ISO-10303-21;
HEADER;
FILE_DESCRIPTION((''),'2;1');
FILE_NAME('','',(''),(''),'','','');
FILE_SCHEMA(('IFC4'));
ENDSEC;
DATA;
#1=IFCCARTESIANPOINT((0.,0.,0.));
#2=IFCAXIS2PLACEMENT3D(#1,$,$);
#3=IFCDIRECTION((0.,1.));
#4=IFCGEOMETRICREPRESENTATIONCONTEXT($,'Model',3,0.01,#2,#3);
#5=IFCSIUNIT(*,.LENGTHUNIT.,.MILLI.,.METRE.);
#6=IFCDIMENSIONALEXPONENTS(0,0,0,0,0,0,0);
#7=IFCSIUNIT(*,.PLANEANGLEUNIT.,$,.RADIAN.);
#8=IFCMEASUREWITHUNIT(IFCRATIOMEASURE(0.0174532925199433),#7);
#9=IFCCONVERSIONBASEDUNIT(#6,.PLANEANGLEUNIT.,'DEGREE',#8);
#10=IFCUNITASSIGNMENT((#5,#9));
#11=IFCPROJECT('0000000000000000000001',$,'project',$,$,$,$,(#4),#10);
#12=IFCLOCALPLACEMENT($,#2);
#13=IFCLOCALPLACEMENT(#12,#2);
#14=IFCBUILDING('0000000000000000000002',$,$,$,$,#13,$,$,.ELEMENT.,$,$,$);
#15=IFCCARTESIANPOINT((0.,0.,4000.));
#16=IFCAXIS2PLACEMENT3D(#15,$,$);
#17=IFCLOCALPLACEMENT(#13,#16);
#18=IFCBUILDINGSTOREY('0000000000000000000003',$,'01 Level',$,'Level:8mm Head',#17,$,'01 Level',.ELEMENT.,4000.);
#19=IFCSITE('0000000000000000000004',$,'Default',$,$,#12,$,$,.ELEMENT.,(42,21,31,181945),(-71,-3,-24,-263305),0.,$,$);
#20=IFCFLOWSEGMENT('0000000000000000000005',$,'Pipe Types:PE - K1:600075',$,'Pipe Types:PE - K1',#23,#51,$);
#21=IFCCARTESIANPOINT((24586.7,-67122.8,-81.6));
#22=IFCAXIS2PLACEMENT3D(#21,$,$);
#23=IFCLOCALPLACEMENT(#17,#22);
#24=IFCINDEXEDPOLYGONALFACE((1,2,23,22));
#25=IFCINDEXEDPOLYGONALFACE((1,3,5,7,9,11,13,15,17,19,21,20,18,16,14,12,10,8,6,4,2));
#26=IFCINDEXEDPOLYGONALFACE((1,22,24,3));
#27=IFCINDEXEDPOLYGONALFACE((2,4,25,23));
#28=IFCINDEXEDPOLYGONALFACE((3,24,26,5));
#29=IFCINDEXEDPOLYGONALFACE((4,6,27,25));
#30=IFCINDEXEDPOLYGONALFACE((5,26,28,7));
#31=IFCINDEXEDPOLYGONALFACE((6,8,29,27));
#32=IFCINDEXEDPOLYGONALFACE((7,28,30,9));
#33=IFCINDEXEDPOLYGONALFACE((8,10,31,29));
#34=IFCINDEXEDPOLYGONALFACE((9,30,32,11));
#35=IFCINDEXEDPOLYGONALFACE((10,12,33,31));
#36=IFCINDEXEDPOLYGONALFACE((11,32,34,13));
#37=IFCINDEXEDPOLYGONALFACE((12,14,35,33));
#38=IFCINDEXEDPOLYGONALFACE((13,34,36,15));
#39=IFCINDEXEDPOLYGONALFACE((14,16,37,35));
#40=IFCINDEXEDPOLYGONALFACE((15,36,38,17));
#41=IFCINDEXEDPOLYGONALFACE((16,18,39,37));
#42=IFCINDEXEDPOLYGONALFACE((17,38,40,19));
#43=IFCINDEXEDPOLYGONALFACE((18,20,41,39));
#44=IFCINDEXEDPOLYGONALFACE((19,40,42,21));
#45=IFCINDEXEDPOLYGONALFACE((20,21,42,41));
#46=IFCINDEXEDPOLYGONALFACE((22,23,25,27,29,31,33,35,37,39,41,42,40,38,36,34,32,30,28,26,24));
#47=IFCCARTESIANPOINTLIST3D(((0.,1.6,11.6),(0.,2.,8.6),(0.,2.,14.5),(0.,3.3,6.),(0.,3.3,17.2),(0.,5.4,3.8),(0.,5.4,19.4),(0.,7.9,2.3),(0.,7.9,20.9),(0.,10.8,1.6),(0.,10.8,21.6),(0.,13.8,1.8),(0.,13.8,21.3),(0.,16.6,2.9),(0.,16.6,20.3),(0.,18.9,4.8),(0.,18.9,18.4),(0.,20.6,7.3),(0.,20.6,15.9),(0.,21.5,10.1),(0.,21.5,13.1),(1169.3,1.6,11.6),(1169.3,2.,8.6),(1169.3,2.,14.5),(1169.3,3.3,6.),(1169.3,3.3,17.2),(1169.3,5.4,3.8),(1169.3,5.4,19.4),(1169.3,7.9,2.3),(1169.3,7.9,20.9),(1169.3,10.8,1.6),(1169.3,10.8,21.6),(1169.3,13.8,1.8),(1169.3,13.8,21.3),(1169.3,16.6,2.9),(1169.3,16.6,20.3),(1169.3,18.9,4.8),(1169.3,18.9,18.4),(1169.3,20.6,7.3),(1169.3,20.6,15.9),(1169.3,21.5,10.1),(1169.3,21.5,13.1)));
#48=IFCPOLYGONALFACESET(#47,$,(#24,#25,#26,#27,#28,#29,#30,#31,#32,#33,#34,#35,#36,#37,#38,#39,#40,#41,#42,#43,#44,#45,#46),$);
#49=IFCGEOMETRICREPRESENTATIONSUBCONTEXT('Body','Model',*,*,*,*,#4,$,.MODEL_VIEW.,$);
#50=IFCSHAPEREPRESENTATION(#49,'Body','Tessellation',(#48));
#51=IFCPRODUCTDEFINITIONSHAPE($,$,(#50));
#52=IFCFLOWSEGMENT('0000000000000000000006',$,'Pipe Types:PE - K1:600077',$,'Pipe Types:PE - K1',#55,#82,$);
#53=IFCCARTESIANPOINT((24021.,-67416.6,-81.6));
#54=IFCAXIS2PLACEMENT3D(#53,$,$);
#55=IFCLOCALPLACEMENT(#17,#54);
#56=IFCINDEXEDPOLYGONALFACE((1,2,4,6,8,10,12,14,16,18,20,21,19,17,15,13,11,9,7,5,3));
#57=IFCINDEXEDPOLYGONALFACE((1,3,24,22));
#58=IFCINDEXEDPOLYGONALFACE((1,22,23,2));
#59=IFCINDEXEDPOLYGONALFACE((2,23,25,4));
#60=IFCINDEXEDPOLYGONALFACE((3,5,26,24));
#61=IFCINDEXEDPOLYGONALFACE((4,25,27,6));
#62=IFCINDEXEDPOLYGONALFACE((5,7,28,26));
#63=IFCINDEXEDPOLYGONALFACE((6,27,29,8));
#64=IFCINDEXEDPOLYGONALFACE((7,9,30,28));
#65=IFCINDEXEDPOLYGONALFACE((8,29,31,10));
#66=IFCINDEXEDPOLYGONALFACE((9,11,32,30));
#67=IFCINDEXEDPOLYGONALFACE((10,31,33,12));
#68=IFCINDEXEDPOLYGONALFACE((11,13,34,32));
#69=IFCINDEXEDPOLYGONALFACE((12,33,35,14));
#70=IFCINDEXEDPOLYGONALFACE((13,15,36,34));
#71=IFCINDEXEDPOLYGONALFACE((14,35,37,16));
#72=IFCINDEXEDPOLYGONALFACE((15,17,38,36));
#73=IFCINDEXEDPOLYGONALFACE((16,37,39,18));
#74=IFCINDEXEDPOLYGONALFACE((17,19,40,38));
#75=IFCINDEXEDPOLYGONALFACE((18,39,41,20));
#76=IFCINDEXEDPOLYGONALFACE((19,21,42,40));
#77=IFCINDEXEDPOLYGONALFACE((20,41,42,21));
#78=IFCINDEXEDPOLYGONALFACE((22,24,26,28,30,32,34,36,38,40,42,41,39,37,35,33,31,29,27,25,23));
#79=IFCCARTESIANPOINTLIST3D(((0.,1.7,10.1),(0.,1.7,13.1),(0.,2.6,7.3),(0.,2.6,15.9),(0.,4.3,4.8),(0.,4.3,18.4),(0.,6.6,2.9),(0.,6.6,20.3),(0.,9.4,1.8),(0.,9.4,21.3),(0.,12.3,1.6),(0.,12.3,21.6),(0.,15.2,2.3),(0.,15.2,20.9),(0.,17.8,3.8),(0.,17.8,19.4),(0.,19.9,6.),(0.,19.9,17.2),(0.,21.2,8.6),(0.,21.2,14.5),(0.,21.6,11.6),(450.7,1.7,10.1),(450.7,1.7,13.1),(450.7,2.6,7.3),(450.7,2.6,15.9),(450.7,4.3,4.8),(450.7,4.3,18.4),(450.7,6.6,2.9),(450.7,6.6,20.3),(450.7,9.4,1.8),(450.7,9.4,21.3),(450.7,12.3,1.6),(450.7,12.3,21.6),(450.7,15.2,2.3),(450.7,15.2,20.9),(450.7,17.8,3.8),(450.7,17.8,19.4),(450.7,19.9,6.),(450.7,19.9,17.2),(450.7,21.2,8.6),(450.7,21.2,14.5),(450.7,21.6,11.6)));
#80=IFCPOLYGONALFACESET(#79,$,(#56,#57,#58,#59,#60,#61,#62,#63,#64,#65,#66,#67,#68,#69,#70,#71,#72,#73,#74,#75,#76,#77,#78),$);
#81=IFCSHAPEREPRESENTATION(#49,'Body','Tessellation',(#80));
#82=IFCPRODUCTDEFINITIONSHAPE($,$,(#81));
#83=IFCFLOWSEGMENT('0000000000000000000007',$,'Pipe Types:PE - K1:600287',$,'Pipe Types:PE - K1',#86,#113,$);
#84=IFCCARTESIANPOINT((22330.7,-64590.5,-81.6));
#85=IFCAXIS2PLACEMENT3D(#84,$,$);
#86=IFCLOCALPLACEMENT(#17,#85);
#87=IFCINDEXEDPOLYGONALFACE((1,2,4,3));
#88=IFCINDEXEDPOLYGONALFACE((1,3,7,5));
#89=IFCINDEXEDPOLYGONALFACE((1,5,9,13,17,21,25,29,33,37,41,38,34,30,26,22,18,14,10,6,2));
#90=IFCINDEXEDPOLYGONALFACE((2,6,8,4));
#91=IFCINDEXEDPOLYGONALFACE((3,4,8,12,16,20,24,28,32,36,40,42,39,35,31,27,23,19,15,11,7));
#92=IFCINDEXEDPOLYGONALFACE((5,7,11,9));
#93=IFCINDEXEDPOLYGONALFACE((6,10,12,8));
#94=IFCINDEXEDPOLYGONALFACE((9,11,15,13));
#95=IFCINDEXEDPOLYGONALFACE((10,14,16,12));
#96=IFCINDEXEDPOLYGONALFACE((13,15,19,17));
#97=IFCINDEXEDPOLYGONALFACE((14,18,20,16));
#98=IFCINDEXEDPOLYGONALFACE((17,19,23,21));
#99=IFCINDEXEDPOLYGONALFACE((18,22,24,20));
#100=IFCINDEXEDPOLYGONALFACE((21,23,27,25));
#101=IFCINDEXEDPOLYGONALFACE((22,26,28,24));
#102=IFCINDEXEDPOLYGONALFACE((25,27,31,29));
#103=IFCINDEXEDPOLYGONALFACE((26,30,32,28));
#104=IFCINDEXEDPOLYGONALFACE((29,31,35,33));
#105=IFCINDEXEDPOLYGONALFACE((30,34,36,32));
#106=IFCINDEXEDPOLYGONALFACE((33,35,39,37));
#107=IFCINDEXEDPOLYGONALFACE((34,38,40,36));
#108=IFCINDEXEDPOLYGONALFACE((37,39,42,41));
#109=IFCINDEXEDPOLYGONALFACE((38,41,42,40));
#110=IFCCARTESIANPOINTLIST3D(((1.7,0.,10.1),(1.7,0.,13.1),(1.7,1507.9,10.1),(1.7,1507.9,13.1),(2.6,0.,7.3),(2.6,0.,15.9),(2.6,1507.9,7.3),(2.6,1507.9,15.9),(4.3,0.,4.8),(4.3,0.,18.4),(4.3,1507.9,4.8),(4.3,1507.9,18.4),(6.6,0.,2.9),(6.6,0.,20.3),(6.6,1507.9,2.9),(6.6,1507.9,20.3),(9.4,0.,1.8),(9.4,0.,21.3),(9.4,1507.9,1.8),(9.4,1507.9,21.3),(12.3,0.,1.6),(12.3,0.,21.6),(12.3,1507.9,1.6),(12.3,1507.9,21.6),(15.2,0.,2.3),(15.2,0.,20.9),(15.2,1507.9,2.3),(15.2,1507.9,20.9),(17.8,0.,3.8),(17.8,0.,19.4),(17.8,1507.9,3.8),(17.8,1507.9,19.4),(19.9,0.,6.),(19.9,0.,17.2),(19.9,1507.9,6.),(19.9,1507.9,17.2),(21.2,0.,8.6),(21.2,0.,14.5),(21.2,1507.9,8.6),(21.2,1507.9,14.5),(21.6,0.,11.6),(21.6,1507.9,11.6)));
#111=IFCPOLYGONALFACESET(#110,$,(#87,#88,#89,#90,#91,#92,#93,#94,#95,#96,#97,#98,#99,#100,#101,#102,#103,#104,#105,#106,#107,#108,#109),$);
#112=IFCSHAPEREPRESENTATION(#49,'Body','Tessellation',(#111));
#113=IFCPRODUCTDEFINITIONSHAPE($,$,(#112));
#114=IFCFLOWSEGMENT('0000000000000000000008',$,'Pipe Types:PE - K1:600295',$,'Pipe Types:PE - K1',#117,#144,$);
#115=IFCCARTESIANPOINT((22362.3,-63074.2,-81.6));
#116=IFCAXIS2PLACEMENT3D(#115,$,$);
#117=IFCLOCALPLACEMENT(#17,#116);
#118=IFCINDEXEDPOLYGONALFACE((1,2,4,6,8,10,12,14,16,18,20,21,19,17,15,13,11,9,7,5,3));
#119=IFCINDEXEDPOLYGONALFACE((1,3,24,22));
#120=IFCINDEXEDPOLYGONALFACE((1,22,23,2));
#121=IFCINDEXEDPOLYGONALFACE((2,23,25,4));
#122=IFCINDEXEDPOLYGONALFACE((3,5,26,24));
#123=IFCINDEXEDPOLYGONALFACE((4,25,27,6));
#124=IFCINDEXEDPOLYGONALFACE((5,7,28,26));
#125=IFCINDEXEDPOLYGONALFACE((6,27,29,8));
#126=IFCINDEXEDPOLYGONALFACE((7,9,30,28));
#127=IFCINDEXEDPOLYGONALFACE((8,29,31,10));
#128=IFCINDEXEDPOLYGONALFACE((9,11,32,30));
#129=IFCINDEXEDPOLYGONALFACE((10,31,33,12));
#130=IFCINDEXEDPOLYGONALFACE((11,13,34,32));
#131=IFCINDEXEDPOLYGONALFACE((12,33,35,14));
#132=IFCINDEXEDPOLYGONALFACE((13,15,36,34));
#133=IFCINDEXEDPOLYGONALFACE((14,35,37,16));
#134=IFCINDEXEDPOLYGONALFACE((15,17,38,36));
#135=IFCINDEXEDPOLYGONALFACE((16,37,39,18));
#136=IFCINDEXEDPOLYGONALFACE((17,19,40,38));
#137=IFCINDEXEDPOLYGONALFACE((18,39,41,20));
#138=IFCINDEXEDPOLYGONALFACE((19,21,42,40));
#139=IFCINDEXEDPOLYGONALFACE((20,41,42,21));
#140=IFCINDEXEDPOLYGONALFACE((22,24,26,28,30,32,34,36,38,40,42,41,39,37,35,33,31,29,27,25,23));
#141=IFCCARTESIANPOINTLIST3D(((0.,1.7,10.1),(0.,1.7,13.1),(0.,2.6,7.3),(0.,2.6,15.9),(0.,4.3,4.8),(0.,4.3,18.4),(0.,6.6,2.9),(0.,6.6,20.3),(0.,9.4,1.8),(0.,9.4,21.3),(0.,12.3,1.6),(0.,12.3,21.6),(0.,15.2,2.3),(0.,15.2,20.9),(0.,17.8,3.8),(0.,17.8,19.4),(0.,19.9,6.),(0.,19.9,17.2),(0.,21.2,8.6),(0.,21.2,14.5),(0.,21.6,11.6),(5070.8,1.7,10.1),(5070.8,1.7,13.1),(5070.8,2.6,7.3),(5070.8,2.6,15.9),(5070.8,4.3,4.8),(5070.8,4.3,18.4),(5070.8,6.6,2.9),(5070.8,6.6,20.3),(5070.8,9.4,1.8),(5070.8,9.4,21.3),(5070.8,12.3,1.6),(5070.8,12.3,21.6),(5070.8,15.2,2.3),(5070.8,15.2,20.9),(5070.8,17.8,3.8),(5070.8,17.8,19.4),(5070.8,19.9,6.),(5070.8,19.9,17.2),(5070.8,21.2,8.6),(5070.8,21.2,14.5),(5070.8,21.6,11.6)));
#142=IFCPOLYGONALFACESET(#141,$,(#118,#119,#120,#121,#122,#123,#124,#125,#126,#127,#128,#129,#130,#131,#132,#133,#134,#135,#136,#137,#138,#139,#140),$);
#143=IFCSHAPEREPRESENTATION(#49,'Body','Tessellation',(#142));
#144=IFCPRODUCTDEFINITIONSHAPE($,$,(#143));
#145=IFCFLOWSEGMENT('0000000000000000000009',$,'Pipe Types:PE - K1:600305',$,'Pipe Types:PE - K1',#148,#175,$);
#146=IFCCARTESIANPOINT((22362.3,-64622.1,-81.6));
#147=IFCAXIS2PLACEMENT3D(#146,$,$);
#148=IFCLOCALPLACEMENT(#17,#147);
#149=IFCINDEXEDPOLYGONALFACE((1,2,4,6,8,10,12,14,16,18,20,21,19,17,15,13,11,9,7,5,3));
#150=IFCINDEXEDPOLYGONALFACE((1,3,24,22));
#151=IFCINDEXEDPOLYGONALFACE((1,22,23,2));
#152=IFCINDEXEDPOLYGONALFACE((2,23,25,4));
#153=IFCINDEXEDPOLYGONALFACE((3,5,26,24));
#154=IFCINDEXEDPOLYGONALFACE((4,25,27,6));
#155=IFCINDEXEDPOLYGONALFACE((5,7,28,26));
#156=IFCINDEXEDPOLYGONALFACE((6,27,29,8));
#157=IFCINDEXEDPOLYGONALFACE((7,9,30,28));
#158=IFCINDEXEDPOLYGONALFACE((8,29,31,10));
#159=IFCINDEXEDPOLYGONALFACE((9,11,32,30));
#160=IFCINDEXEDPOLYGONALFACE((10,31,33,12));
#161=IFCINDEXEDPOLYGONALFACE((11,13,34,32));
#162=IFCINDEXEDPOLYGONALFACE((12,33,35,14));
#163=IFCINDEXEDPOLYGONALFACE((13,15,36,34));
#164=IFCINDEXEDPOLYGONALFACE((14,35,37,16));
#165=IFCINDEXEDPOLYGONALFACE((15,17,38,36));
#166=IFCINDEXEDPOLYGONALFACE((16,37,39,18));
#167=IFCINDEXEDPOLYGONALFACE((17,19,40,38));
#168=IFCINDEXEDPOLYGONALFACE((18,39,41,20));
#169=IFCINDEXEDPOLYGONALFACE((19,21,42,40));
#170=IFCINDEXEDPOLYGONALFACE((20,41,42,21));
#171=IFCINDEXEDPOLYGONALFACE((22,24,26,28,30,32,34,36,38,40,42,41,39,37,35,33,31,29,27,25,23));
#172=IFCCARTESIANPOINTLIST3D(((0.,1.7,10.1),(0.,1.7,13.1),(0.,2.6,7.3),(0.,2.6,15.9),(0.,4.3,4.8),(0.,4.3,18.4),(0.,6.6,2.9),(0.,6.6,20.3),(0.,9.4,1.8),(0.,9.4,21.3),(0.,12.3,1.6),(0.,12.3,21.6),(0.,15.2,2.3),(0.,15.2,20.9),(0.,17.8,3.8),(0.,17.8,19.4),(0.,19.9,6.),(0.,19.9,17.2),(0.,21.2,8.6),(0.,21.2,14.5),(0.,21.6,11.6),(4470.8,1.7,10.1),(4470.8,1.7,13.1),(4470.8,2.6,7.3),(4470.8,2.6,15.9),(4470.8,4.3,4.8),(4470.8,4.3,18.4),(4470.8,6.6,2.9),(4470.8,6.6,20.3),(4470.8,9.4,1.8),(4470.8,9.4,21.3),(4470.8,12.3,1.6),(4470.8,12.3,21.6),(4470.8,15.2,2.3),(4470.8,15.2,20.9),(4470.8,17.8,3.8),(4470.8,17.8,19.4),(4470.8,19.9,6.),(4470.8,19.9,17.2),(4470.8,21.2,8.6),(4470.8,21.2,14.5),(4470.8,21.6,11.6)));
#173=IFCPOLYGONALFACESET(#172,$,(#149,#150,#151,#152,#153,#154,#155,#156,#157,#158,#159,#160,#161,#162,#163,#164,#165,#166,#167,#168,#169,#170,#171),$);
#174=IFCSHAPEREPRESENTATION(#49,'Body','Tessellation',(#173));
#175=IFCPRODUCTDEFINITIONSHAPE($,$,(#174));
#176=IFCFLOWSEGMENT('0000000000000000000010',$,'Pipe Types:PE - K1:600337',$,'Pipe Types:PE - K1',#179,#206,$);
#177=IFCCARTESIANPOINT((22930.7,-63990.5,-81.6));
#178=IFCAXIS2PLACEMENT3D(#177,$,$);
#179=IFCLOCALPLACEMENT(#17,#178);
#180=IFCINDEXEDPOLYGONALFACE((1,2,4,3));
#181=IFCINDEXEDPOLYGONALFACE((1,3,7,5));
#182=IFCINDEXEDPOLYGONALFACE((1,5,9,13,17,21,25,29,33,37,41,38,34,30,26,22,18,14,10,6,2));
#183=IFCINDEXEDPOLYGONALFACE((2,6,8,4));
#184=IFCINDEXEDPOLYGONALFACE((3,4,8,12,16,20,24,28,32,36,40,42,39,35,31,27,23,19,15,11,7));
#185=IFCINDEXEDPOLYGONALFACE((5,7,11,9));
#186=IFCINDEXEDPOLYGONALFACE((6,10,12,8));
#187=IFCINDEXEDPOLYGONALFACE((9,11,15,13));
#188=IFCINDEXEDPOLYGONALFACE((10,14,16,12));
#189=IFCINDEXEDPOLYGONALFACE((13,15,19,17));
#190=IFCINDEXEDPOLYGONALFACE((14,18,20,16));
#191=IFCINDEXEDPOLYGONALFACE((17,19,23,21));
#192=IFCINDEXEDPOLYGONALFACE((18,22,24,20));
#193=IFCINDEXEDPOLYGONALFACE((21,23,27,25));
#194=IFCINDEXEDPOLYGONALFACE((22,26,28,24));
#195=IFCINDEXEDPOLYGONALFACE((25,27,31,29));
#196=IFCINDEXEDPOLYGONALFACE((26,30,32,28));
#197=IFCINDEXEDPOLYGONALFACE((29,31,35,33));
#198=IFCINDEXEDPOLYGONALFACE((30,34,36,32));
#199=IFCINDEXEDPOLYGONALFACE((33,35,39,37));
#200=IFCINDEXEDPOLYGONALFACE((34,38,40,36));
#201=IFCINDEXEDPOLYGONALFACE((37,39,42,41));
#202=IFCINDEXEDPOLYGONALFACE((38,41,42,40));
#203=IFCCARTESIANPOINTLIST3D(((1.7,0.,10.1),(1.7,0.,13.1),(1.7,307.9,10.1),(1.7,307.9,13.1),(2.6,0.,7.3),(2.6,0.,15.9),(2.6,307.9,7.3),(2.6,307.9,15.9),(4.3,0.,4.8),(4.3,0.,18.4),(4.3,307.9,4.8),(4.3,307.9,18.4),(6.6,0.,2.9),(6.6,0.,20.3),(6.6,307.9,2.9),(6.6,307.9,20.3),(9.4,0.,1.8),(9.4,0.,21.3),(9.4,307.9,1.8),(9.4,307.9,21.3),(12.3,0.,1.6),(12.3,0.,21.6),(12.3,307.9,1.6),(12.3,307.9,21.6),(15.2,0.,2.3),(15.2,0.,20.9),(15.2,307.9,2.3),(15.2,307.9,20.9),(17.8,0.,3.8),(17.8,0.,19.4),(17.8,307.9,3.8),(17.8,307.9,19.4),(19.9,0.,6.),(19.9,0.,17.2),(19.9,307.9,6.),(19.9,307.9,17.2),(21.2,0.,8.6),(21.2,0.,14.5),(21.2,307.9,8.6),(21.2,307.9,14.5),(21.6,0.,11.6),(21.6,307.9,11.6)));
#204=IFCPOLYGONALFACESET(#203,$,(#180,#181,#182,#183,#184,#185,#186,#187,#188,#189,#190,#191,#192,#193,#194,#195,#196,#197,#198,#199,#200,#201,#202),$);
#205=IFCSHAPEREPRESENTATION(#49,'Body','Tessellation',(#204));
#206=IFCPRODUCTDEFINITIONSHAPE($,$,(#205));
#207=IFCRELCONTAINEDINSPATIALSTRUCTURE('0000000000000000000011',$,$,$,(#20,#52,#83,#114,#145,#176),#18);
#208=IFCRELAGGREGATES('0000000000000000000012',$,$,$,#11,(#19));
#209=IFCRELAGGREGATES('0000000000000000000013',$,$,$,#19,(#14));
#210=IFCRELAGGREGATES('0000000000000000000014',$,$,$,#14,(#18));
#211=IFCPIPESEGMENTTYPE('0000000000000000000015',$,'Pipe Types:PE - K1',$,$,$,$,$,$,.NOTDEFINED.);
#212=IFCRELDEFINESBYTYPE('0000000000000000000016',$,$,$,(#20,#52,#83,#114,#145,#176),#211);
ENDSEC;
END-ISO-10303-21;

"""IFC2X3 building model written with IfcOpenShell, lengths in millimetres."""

from ifc_helpers import new_model, entity, si_unit, converted_unit, direction, frame, frame_2d, origin, origin_2d_with_axis, place, context, subcontext, project, spatial, circle, extrude, type_object, element, save


model = new_model("IFC2X3")

# Units and contexts
model_context = context("Model", 3, precision=0.01, world=origin(), true_north=direction((0.0, 1.0)))
body_context = subcontext(model_context, "Body", "Model", "MODEL_VIEW")
ifc_project = project(units=[si_unit("LENGTHUNIT", "METRE", prefix="MILLI"), converted_unit("PLANEANGLEUNIT", "DEGREE", entity("IfcRatioMeasure", 0.0174532925199433), si_unit("PLANEANGLEUNIT", "RADIAN"), dimensions=[0, 0, 0, 0, 0, 0, 0])], contexts=[model_context])

# Site, building, storey
site_placement = place(None, origin())
site = spatial("IfcSite", under=ifc_project, at=site_placement, Name="Default", CompositionType="ELEMENT", RefLatitude=(42, 21, 31, 181945), RefLongitude=(-71, -3, -24, -263305), RefElevation=0.0)
building_placement = place(site_placement, origin())
building = spatial("IfcBuilding", under=site, at=building_placement, CompositionType="ELEMENT")
storey_placement = place(building_placement, frame((0.0, 0.0, 4000.0)))
storey = spatial("IfcBuildingStorey", under=building, at=storey_placement, Name="01 Level", ObjectType="Level:8mm Head", LongName="01 Level", CompositionType="ELEMENT", Elevation=4000.0)

# Flow segments
pipe_segment_type = type_object("IfcPipeSegmentType", Name="Pipe Types:PE - K1", PredefinedType="NOTDEFINED")
flow_segment_1_placement = place(storey_placement, frame((24586.7, -67122.8, -81.6)))
element("IfcFlowSegment", 1, at=flow_segment_1_placement, inside=storey, type_object=pipe_segment_type, Name="Pipe Types:PE - K1:600075", ObjectType="Pipe Types:PE - K1", context=body_context, shape_type="SweptSolid", body=[
    extrude(circle(Radius=10.0, at=origin_2d_with_axis()), frame((0.0, 11.6, 11.6), z_axis=(1.0, 0.0, 0.0), x_axis=(0.0, -1.0, 0.0)), (0.0, 0.0, 1.0), 1169.3),
])
flow_segment_2_placement = place(storey_placement, frame((24021.0, -67416.6, -81.6)))
element("IfcFlowSegment", 2, at=flow_segment_2_placement, inside=storey, type_object=pipe_segment_type, Name="Pipe Types:PE - K1:600077", ObjectType="Pipe Types:PE - K1", context=body_context, shape_type="SweptSolid", body=[
    extrude(circle(Radius=10.0, at=origin_2d_with_axis()), frame((0.0, 11.6, 11.6), z_axis=(1.0, 0.0, 0.0), x_axis=(0.0, 1.0, 0.0)), (0.0, 0.0, 1.0), 450.7),
])
flow_segment_3_placement = place(storey_placement, frame((22330.7, -64590.5, -81.6)))
element("IfcFlowSegment", 3, at=flow_segment_3_placement, inside=storey, type_object=pipe_segment_type, Name="Pipe Types:PE - K1:600287", ObjectType="Pipe Types:PE - K1", context=body_context, shape_type="SweptSolid", body=[
    extrude(circle(Radius=10.0, at=origin_2d_with_axis()), frame((11.6, 0.0, 11.6), z_axis=(0.0, 1.0, 0.0), x_axis=(1.0, 0.0, 0.0)), (0.0, 0.0, 1.0), 1507.9),
])
flow_segment_4_placement = place(storey_placement, frame((22362.3, -63074.2, -81.6)))
element("IfcFlowSegment", 4, at=flow_segment_4_placement, inside=storey, type_object=pipe_segment_type, Name="Pipe Types:PE - K1:600295", ObjectType="Pipe Types:PE - K1", context=body_context, shape_type="SweptSolid", body=[
    extrude(circle(Radius=10.0, at=frame_2d((0.0, 0.0), x_axis=(1.0, 0.0))), frame((0.0, 11.6, 11.6), z_axis=(1.0, 0.0, 0.0), x_axis=(0.0, 1.0, 0.0)), (0.0, 0.0, 1.0), 5070.8),
])
flow_segment_5_placement = place(storey_placement, frame((22362.3, -64622.1, -81.6)))
element("IfcFlowSegment", 5, at=flow_segment_5_placement, inside=storey, type_object=pipe_segment_type, Name="Pipe Types:PE - K1:600305", ObjectType="Pipe Types:PE - K1", context=body_context, shape_type="SweptSolid", body=[
    extrude(circle(Radius=10.0, at=frame_2d((0.0, 0.0), x_axis=(1.0, 0.0))), frame((0.0, 11.6, 11.6), z_axis=(1.0, 0.0, 0.0), x_axis=(0.0, 1.0, 0.0)), (0.0, 0.0, 1.0), 4470.8),
])
flow_segment_6_placement = place(storey_placement, frame((22930.7, -63990.5, -81.6)))
element("IfcFlowSegment", 6, at=flow_segment_6_placement, inside=storey, type_object=pipe_segment_type, Name="Pipe Types:PE - K1:600337", ObjectType="Pipe Types:PE - K1", context=body_context, shape_type="SweptSolid", body=[
    extrude(circle(Radius=10.0, at=origin_2d_with_axis()), frame((11.6, 0.0, 11.6), z_axis=(0.0, 1.0, 0.0), x_axis=(1.0, 0.0, 0.0)), (0.0, 0.0, 1.0), 307.9),
])

save(model, "model.ifc")
